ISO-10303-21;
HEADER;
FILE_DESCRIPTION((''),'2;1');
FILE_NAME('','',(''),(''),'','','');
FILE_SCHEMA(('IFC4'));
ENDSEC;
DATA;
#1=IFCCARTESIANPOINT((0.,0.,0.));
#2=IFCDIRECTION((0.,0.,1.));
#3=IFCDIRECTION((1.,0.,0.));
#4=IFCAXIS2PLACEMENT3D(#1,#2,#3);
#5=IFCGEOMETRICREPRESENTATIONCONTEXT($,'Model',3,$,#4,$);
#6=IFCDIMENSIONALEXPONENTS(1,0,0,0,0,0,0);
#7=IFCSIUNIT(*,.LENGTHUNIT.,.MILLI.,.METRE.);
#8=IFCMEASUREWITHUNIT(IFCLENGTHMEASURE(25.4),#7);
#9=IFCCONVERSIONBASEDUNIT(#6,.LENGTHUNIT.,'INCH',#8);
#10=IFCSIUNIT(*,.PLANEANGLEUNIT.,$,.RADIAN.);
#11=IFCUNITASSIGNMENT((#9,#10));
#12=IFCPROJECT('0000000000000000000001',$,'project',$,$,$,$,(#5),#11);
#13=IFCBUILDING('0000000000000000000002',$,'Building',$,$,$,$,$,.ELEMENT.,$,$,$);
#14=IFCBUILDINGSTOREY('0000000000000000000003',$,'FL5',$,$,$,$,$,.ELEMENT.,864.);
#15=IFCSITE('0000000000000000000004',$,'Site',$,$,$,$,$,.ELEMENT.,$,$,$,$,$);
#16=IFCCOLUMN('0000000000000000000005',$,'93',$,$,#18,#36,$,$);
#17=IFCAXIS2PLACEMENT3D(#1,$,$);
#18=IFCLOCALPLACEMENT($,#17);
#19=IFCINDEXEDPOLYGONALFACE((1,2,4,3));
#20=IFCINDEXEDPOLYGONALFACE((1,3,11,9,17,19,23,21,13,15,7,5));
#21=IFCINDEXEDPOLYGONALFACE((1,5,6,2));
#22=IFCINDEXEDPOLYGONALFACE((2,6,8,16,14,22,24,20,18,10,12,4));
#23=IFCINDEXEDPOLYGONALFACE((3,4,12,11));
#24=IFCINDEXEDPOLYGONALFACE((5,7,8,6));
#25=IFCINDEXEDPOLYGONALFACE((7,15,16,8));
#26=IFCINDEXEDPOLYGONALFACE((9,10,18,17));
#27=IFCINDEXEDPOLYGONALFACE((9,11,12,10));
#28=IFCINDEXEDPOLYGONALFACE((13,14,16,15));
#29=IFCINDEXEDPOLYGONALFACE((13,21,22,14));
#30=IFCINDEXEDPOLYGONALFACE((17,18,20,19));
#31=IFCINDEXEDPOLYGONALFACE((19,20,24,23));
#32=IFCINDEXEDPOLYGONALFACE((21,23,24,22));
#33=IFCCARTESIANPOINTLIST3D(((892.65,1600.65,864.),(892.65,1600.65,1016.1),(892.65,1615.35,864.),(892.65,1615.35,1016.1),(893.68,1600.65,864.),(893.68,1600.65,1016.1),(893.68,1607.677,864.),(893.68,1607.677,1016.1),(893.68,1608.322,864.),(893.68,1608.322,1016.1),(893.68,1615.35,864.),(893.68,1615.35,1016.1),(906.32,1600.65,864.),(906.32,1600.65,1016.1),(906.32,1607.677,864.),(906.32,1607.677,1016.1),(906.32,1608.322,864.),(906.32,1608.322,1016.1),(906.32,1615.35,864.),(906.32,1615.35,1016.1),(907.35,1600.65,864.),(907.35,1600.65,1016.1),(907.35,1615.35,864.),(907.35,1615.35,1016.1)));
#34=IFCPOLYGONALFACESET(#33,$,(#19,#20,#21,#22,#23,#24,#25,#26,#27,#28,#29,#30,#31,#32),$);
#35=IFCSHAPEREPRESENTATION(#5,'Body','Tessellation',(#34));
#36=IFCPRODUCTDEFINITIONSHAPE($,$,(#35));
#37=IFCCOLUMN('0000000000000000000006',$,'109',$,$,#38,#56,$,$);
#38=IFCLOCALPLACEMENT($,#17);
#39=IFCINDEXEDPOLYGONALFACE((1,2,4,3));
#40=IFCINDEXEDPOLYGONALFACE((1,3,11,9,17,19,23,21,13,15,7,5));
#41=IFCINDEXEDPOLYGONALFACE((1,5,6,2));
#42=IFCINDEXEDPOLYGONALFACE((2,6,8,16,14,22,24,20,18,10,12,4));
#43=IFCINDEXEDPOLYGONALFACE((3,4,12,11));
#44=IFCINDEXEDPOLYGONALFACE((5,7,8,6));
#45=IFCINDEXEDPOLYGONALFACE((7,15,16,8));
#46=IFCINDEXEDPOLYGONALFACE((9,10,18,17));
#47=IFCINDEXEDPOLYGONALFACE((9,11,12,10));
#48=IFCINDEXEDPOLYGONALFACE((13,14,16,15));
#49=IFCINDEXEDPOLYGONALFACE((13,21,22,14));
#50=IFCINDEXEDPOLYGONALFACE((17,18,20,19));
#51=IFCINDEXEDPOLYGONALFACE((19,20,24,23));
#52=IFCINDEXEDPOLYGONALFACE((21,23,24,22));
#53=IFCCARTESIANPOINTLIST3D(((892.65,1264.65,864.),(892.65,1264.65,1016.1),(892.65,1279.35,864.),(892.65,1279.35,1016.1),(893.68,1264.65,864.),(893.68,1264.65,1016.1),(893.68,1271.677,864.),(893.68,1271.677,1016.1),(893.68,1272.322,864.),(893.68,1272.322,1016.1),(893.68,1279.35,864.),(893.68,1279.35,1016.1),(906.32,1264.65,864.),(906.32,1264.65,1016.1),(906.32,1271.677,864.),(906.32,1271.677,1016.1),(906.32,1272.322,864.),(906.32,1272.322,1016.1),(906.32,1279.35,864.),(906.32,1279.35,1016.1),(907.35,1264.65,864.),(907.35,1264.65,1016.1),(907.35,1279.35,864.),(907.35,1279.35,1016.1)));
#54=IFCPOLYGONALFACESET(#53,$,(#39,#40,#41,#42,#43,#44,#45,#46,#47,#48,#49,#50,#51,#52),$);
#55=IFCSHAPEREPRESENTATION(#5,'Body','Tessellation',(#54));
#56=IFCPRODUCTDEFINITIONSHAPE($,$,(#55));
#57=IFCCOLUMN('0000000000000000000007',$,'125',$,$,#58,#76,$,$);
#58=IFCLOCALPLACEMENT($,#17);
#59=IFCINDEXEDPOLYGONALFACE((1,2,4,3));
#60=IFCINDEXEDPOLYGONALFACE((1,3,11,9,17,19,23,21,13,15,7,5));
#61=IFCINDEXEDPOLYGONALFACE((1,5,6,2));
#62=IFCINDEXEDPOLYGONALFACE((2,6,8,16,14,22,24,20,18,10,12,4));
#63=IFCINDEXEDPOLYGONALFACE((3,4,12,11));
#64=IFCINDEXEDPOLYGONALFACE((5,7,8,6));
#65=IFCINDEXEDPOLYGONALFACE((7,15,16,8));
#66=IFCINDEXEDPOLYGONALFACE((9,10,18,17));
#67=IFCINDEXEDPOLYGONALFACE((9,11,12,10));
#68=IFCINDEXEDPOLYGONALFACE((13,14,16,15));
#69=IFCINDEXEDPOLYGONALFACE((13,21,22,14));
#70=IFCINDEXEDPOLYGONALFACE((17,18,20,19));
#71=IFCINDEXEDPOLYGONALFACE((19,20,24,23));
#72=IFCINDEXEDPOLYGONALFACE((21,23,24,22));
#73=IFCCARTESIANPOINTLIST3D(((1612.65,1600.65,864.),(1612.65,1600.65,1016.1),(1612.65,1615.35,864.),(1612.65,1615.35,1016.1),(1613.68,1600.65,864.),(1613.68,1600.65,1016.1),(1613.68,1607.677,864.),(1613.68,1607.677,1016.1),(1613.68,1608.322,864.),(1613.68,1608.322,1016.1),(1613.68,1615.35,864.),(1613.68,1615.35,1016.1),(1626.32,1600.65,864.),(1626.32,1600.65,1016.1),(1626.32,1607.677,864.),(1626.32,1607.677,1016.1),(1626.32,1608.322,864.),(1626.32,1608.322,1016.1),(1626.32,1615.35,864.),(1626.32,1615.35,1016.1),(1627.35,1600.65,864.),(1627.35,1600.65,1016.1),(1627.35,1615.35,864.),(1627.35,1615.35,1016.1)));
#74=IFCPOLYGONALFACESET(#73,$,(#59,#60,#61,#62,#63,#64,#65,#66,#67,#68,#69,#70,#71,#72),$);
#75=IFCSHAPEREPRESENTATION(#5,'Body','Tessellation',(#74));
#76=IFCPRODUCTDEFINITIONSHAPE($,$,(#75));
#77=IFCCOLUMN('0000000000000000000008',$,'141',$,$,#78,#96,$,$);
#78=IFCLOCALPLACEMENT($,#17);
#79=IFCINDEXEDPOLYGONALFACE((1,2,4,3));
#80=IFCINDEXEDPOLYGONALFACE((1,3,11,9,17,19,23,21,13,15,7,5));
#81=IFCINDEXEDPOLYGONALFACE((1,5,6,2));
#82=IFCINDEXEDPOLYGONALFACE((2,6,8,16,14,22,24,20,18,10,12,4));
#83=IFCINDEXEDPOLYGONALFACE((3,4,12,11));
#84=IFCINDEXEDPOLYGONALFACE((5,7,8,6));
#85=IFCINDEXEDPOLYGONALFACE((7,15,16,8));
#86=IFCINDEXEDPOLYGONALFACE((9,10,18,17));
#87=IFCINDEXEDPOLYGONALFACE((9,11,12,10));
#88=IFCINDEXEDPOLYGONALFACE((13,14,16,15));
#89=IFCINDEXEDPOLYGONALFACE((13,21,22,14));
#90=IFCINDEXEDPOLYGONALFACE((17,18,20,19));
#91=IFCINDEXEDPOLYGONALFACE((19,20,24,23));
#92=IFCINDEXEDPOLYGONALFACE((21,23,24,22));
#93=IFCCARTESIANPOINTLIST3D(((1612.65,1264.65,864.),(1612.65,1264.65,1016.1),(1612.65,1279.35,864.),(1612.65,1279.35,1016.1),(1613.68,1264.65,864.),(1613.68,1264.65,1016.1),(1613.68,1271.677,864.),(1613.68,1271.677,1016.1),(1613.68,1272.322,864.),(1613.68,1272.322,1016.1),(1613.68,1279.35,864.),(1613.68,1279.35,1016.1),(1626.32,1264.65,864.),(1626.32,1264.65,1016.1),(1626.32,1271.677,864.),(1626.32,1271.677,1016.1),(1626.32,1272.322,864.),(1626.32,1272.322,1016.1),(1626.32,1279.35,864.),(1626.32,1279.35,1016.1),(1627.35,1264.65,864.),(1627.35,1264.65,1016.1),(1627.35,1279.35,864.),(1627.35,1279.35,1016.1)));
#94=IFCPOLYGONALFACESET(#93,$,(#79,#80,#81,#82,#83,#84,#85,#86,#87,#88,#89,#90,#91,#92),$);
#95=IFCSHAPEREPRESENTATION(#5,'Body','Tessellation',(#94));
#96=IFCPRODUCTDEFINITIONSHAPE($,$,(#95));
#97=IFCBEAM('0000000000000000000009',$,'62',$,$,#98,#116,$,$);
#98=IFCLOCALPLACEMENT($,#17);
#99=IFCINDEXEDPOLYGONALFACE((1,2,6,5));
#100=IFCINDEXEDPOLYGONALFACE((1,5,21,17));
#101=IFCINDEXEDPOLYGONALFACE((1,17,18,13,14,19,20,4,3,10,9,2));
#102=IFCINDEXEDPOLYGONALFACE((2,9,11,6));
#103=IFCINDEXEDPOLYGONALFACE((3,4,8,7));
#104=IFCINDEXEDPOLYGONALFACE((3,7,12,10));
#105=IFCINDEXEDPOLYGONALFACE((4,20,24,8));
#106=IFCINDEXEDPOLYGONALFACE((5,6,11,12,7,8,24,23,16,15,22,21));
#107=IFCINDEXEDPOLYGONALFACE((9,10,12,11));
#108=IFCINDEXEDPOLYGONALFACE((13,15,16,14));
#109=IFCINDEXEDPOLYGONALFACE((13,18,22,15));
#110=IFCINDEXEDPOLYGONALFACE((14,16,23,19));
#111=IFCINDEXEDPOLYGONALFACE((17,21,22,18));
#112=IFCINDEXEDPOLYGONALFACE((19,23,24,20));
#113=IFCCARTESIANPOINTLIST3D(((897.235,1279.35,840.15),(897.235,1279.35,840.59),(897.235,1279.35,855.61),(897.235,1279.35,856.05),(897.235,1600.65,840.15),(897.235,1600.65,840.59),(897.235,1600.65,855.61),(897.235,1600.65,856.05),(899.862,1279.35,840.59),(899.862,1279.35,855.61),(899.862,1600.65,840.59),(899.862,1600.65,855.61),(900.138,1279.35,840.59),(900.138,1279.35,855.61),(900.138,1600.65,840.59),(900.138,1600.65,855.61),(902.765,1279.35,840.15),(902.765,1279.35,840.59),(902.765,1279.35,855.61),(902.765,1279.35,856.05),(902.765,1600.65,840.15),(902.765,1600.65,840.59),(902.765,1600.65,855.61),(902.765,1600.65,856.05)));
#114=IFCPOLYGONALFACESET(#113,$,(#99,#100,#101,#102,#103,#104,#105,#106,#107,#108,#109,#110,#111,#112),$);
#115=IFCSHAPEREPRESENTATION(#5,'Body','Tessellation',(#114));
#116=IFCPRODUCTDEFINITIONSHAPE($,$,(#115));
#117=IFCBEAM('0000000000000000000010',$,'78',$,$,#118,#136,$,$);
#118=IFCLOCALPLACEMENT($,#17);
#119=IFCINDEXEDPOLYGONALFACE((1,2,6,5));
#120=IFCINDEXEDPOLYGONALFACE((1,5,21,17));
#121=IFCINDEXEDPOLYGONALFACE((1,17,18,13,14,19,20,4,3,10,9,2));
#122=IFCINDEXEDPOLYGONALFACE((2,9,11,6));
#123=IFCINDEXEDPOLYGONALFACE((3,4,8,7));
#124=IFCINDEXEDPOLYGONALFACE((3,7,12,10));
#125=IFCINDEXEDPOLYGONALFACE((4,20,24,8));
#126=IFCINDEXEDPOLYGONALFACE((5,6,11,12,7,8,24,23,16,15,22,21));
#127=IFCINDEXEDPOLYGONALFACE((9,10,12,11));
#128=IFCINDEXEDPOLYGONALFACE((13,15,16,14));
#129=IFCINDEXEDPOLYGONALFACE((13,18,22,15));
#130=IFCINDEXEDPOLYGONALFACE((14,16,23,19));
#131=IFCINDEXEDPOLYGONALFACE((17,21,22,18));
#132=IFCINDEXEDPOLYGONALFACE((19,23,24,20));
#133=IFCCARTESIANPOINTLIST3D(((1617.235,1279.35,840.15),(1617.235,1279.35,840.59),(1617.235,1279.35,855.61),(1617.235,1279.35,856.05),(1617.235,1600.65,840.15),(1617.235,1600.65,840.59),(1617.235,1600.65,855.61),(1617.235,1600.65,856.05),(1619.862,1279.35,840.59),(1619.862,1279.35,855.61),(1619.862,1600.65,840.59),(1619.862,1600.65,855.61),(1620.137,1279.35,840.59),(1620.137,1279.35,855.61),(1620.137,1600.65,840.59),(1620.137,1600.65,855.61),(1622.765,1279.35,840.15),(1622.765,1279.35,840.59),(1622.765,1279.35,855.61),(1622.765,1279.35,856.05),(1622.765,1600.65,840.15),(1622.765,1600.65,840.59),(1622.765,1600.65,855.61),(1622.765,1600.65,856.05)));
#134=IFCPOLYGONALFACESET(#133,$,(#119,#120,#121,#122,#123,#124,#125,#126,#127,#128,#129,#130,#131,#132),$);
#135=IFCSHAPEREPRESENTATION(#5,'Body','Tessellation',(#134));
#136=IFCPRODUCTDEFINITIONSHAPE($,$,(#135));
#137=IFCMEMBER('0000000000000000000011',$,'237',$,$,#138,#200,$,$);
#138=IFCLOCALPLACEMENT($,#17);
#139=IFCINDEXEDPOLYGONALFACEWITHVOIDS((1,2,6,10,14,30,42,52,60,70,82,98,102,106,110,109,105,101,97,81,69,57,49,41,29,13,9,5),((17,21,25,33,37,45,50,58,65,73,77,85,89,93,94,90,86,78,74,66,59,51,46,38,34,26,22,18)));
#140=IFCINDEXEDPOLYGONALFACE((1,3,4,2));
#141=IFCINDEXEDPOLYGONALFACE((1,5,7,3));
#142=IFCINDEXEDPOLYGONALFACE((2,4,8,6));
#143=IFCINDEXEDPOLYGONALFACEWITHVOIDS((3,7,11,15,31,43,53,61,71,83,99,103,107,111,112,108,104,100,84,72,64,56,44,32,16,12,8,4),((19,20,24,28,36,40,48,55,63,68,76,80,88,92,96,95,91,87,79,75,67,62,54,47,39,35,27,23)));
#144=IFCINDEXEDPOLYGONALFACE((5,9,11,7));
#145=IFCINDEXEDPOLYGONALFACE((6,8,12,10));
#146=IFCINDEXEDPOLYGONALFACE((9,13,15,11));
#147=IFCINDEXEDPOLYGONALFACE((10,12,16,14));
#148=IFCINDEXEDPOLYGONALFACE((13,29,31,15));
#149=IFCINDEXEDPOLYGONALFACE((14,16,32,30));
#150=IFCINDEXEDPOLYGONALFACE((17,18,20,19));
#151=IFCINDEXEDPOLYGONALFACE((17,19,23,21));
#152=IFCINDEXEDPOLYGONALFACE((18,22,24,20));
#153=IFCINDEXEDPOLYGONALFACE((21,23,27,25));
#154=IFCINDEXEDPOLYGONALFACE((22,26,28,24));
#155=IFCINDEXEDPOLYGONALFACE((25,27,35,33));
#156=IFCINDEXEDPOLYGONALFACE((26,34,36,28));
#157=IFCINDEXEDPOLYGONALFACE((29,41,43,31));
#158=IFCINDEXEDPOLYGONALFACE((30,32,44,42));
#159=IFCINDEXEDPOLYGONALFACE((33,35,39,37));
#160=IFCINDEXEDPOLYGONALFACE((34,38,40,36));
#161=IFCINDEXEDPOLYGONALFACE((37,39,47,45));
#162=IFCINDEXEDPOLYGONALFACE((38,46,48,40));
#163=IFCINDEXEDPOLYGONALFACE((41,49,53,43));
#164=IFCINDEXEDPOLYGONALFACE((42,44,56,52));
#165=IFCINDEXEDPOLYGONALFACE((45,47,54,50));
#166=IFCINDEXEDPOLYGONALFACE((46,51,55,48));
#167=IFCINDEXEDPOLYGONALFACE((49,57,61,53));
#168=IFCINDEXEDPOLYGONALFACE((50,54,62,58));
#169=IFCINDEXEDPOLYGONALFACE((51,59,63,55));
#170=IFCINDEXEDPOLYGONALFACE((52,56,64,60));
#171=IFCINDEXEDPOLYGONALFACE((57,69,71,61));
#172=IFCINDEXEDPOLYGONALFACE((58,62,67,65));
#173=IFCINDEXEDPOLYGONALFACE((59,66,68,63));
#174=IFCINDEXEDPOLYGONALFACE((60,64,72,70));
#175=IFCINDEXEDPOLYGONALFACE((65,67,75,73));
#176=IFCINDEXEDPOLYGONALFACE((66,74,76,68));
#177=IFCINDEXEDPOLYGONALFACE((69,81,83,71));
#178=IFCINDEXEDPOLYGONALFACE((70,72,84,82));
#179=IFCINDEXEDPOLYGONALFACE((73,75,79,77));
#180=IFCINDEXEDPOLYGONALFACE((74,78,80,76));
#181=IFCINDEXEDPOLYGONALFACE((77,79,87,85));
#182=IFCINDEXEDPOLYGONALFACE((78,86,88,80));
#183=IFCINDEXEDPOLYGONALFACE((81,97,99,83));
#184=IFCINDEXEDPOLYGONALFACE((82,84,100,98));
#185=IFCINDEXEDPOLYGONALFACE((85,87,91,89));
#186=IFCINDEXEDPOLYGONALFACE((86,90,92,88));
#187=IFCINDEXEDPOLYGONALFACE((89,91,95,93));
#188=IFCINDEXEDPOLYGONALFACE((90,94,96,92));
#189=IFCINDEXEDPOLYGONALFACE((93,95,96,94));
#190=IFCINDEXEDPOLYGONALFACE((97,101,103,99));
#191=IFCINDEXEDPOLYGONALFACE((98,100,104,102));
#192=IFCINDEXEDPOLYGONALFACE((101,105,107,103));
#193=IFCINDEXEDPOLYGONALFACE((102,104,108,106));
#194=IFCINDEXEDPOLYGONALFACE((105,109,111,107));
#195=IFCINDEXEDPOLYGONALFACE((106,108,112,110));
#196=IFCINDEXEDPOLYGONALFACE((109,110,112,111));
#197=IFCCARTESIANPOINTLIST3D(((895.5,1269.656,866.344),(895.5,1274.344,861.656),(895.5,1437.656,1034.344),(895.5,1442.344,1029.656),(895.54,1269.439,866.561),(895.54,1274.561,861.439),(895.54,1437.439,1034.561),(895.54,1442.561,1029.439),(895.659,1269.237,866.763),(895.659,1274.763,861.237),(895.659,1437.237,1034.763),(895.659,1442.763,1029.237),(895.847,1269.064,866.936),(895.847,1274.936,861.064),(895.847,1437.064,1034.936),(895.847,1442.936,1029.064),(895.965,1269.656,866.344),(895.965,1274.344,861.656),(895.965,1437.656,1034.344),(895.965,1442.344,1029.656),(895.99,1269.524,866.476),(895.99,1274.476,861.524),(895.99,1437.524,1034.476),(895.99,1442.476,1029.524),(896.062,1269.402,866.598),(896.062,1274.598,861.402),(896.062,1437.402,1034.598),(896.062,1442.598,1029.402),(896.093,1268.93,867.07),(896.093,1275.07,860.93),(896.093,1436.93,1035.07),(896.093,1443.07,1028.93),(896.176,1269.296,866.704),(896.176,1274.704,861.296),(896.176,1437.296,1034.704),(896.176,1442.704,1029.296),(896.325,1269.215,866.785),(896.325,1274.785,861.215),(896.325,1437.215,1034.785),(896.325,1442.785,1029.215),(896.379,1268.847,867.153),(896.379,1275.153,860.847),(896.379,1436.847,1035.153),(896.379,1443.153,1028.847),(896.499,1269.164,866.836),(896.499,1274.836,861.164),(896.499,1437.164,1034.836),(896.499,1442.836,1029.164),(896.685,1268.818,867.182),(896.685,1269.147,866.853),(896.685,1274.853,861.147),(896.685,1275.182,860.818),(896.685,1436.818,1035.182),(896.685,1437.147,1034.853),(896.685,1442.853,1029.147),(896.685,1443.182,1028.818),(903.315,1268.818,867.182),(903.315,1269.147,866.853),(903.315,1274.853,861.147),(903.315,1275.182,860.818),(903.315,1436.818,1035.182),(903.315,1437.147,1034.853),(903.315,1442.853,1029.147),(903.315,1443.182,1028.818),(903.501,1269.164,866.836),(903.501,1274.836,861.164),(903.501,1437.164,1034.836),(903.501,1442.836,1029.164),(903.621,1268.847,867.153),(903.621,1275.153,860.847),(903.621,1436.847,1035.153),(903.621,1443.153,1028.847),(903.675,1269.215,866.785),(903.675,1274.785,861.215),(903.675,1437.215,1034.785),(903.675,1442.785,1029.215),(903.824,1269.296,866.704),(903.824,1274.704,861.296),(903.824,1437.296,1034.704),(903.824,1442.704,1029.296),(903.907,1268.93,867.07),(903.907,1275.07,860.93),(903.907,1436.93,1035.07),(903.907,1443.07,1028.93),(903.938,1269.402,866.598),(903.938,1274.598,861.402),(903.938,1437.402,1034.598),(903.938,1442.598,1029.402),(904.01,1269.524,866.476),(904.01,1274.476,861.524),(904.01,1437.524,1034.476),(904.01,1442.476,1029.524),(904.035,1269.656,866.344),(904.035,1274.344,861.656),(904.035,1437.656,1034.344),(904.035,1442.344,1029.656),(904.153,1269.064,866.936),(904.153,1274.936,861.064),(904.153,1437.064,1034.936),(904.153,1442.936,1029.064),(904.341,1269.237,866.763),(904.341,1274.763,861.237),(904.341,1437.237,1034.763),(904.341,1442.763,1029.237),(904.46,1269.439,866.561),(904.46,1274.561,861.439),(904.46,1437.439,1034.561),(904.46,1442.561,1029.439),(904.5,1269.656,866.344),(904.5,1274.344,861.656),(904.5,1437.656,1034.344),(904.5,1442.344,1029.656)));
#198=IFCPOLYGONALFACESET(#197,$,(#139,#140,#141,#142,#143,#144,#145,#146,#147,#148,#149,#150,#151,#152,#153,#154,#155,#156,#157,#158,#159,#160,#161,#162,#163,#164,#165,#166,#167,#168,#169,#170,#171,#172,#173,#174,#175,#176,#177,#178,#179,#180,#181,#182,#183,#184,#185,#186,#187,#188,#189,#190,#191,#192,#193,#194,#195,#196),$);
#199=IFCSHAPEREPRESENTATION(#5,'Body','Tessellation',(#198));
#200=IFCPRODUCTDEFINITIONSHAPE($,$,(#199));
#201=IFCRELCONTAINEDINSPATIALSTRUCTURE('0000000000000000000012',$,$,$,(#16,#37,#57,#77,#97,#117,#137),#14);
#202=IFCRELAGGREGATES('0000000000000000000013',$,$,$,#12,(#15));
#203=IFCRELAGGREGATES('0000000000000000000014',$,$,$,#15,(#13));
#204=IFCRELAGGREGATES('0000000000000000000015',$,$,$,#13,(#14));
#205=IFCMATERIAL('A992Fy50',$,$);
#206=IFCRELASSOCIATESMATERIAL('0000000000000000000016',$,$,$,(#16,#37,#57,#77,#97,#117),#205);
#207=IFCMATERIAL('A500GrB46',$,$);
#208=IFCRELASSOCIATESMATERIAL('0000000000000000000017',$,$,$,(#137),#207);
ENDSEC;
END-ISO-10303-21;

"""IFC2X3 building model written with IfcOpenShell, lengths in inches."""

from ifc_helpers import new_model, entity, si_unit, converted_unit, frame, origin_with_axes, origin_2d_with_axis, place, context, project, spatial, hollow_rectangle, i_section, transform_2d, derived_profile, extrude, material, element, save


model = new_model("IFC2X3")

# Units and contexts
model_context = context("Model", 3, world=origin_with_axes())
ifc_project = project(units=[converted_unit("LENGTHUNIT", "INCH", entity("IfcLengthMeasure", 25.4), si_unit("LENGTHUNIT", "METRE", prefix="MILLI"), dimensions=[1, 0, 0, 0, 0, 0, 0]), si_unit("PLANEANGLEUNIT", "RADIAN")], contexts=[model_context])

# Site, building, storey
site = spatial("IfcSite", under=ifc_project, Name="Site", CompositionType="ELEMENT")
building = spatial("IfcBuilding", under=site, Name="Building", CompositionType="ELEMENT")
storey = spatial("IfcBuildingStorey", under=building, Name="FL5", CompositionType="ELEMENT", Elevation=864.0)

# Columns
ifc_material_1 = material(Name="A992Fy50")
for number, where, z_axis, x_axis, name in (
    (1, (900.0, 1608.0, 864.0), (0.0, 0.0, 1.0), (0.0, -1.0, 0.0), "93"),
    (2, (900.0, 1272.0, 864.0), (0.0, 0.0, 1.0), (0.0, -1.0, 0.0), "109"),
    (3, (1620.0, 1608.0, 864.0), (0.0, 0.0, 1.0), (0.0, -1.0, 0.0), "125"),
    (4, (1620.0, 1272.0, 864.0), (0.0, 0.0, 1.0), (0.0, -1.0, 0.0), "141"),
):
    element("IfcColumn", number, at=place(None, frame(where, z_axis=z_axis, x_axis=x_axis)), inside=storey, material=ifc_material_1, Name=name, context=model_context, shape_type="SweptSolid", body=[
        extrude(i_section(OverallWidth=14.7, OverallDepth=14.7, WebThickness=0.645, FlangeThickness=1.03, at=origin_2d_with_axis()), origin_with_axes(), (0.0, 0.0, 1.0), 152.1),
    ])

# Beams
for number, where, z_axis, x_axis, name in (
    (5, (900.0, 1279.35, 864.0), (0.0, 1.0, 0.0), (-1.0, 0.0, 0.0), "62"),
    (6, (1620.0, 1279.35, 864.0), (0.0, 1.0, 0.0), (-1.0, 0.0, 0.0), "78"),
):
    element("IfcBeam", number, at=place(None, frame(where, z_axis=z_axis, x_axis=x_axis)), inside=storey, material=ifc_material_1, Name=name, context=model_context, shape_type="SweptSolid", body=[
        extrude(derived_profile(i_section(OverallWidth=5.53, OverallDepth=15.9, WebThickness=0.275, FlangeThickness=0.44, at=origin_2d_with_axis()), transform_2d((0.0, -7.95))), origin_with_axes(), (0.0, 0.0, 1.0), 321.3),
    ])

# Member
ifc_material_2 = material(Name="A500GrB46")
for number, where, z_axis, x_axis, name in (
    (7, (900.0, 1272.0, 864.0), (0.0, 0.707107, 0.707107), (-1.0, 0.0, 0.0), "237"),
):
    element("IfcMember", number, at=place(None, frame(where, z_axis=z_axis, x_axis=x_axis)), inside=storey, material=ifc_material_2, Name=name, context=model_context, shape_type="SweptSolid", body=[
        extrude(hollow_rectangle(XDim=9.0, YDim=9.0, WallThickness=0.465, InnerFilletRadius=0.72, OuterFilletRadius=1.185, at=origin_2d_with_axis()), origin_with_axes(), (0.0, 0.0, 1.0), 237.588),
    ])

save(model, "model.ifc")
